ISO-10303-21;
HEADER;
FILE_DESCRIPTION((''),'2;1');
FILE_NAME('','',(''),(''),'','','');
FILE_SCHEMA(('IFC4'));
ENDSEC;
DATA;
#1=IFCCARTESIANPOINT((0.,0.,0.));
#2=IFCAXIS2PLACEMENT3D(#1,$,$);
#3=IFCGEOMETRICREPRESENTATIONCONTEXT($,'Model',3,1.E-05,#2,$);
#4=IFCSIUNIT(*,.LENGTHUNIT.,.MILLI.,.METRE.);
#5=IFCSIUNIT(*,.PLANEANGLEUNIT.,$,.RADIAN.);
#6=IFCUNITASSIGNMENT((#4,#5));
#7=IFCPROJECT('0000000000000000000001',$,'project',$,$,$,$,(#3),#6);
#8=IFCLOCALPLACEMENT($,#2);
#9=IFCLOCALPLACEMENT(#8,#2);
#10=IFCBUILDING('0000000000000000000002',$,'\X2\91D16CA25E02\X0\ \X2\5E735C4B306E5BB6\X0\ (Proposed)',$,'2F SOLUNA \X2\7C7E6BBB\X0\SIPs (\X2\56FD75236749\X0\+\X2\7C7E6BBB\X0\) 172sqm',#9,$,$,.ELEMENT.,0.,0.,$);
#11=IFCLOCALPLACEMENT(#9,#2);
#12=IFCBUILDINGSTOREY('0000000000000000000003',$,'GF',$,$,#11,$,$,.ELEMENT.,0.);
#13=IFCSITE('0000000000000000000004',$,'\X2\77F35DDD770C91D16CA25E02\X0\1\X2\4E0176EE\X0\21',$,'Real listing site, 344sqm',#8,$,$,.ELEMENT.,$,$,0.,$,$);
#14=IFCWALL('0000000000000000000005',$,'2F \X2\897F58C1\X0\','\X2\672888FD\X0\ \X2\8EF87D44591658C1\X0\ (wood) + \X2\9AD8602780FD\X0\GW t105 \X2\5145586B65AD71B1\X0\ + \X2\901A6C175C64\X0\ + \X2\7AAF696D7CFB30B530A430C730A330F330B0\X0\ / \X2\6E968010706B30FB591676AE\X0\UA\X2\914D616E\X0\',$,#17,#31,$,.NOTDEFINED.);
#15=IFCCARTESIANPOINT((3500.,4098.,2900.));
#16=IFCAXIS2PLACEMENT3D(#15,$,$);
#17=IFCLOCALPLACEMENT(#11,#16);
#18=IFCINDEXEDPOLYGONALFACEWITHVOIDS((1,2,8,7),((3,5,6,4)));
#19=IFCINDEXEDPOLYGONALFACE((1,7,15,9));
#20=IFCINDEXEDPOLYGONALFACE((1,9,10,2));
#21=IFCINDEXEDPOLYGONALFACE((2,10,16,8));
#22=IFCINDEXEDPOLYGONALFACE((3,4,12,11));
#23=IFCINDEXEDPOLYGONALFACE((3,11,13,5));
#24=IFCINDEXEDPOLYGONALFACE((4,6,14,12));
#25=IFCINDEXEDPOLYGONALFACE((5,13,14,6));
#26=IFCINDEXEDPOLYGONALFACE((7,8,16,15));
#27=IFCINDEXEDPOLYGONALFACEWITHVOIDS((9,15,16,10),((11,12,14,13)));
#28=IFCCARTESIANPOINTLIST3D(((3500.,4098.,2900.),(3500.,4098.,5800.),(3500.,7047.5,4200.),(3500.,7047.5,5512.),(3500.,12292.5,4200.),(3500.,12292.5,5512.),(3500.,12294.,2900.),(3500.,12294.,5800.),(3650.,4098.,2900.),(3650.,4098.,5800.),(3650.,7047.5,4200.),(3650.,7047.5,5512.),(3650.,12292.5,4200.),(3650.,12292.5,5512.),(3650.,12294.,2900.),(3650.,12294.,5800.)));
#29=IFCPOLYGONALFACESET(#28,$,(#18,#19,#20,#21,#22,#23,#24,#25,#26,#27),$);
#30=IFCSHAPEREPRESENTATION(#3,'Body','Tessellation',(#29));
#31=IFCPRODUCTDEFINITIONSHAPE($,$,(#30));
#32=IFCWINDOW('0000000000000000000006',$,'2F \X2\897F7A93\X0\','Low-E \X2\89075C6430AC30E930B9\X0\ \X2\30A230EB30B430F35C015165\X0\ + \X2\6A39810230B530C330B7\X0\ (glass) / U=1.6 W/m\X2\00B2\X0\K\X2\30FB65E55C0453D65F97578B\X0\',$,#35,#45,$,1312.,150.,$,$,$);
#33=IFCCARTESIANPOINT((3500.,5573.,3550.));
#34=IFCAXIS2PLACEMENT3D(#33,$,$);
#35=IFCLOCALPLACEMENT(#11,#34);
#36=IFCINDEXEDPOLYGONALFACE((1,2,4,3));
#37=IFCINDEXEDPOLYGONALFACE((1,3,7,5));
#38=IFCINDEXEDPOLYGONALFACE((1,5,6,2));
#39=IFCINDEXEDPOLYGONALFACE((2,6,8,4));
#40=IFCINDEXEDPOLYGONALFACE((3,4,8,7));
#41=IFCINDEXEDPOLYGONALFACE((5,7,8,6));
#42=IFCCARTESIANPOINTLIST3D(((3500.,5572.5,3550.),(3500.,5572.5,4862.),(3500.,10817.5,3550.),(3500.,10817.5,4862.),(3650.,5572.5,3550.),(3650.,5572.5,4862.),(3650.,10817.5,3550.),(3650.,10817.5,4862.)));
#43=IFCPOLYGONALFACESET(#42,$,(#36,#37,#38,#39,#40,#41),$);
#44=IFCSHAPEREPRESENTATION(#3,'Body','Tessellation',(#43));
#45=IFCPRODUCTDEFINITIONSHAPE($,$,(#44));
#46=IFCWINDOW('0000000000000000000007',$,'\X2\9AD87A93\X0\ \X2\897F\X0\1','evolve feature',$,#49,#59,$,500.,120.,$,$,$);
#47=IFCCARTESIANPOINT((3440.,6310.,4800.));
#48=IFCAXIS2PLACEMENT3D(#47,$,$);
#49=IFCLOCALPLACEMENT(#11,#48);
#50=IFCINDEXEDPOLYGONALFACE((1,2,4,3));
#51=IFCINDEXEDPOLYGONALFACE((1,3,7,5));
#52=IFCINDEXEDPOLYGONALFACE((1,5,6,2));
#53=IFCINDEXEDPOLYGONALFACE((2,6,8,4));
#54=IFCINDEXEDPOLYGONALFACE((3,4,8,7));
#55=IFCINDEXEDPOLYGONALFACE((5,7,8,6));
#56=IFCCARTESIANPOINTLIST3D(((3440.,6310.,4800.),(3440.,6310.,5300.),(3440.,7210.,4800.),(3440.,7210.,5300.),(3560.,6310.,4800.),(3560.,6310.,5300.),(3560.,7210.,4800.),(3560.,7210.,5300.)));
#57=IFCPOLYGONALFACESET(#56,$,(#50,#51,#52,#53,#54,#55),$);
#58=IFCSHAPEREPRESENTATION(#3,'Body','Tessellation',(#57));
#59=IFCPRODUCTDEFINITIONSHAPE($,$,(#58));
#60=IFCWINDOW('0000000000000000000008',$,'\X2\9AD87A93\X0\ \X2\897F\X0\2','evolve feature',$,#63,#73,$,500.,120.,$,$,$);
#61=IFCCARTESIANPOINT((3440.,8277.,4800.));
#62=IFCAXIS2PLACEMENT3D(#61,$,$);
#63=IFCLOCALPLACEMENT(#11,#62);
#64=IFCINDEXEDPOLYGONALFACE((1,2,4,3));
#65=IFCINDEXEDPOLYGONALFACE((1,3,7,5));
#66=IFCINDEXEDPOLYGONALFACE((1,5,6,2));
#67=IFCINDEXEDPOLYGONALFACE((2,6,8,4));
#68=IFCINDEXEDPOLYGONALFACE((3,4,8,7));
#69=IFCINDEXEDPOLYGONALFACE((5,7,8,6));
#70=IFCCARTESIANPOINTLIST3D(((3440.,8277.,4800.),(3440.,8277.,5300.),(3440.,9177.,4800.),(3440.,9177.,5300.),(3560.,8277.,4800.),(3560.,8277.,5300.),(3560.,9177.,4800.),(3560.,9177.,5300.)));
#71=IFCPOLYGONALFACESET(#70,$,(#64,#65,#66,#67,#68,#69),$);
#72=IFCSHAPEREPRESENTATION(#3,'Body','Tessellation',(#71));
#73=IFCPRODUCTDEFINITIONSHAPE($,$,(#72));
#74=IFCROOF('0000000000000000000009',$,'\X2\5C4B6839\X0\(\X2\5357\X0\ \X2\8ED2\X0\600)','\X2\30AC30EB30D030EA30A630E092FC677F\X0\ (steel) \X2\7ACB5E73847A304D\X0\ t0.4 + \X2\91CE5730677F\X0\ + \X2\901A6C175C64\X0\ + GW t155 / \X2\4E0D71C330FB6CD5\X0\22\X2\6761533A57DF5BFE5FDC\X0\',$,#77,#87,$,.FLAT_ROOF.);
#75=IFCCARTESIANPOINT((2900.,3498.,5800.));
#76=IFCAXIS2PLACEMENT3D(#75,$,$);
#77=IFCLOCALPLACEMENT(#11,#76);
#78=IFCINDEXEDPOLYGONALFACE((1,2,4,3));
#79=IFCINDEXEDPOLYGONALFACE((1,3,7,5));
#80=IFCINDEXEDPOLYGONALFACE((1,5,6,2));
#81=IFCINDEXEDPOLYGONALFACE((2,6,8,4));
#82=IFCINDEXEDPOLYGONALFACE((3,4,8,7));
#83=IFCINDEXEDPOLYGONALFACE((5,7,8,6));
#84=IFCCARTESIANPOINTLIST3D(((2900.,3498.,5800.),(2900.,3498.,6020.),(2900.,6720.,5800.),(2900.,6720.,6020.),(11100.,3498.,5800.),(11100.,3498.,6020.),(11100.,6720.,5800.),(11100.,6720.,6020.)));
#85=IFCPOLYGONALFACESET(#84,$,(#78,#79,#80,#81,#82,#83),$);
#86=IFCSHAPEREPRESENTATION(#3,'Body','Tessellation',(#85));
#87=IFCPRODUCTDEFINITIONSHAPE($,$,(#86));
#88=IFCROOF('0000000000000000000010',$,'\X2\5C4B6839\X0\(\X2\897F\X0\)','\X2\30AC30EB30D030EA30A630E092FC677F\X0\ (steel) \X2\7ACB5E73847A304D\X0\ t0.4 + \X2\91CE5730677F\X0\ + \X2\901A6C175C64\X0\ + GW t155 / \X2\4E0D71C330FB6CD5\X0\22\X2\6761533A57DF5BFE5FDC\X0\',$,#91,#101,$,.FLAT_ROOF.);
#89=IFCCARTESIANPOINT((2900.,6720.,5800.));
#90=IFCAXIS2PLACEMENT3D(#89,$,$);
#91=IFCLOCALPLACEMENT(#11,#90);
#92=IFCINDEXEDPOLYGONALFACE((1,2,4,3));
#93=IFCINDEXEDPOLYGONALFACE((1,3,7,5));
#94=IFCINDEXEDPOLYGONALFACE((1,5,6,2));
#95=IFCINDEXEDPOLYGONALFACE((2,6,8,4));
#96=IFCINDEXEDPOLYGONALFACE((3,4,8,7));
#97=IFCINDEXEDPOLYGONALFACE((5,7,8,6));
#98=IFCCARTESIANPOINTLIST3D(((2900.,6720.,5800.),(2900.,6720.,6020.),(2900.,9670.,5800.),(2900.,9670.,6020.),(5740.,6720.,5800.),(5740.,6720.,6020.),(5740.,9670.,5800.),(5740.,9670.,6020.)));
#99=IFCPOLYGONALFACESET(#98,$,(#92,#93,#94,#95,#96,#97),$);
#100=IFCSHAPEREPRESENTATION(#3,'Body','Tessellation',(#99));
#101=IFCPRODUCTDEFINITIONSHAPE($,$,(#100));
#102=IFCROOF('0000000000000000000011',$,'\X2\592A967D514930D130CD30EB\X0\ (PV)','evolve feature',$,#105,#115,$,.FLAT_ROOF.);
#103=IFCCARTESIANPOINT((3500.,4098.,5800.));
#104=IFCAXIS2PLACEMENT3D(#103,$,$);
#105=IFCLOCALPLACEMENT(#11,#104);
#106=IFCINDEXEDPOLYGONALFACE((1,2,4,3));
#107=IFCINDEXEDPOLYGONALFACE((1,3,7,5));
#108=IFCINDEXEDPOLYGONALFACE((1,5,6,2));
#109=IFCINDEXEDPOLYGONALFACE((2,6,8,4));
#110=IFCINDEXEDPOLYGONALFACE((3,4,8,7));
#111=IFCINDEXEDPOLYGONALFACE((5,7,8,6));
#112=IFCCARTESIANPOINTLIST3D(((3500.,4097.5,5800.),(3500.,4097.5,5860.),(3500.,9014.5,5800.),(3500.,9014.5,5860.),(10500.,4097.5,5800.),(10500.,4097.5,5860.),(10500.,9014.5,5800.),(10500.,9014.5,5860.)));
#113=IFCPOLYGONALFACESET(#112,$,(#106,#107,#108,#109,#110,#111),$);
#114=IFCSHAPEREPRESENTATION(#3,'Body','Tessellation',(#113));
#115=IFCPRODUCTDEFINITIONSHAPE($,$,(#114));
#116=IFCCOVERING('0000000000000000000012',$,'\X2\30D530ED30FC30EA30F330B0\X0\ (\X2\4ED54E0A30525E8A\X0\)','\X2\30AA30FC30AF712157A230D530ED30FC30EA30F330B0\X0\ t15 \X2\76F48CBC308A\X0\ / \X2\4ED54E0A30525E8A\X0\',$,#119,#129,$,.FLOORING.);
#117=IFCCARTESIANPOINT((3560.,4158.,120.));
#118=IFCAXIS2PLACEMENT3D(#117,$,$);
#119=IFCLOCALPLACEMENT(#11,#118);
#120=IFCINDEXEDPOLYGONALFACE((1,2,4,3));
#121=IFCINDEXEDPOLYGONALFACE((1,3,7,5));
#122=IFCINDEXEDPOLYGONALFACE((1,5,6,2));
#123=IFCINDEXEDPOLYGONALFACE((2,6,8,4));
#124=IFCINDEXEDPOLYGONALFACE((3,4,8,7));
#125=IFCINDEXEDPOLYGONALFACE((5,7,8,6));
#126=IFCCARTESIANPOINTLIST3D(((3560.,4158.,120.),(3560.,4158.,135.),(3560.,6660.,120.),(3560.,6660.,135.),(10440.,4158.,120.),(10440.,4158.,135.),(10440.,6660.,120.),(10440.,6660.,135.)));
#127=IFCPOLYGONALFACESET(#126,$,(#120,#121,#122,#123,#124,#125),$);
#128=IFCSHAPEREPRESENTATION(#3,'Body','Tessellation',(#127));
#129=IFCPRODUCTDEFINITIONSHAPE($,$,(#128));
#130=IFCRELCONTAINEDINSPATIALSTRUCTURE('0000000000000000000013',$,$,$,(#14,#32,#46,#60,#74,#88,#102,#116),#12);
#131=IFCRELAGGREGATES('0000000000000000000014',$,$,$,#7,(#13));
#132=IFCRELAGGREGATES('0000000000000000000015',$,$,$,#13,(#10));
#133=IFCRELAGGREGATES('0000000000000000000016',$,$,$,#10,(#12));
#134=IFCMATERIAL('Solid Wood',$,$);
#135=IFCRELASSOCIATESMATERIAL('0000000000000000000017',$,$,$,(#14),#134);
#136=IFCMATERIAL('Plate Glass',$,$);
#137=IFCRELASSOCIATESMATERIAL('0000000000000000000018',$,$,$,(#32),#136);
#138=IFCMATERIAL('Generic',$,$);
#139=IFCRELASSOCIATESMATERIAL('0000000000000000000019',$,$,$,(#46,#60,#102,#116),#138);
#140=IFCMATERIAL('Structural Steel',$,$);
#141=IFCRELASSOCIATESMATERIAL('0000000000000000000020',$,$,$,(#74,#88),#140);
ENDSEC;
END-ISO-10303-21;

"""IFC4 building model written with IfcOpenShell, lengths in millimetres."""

from ifc_helpers import new_model, si_unit, frame, frame_2d, origin, place, context, project, spatial, rectangle, extrude, material, element, fill, save


model = new_model("IFC4")

# Units and contexts
model_context = context("Model", 3, precision=1e-05, world=origin())
ifc_project = project(units=[si_unit("LENGTHUNIT", "METRE", prefix="MILLI"), si_unit("PLANEANGLEUNIT", "RADIAN")], contexts=[model_context])

# Site, building, storey
site_placement = place(None, origin())
site = spatial("IfcSite", under=ifc_project, at=site_placement, Name="石川県金沢市1丁目21", ObjectType="Real listing site, 344sqm", CompositionType="ELEMENT", RefElevation=0.0)
building_placement = place(site_placement, origin())
building = spatial("IfcBuilding", under=site, at=building_placement, Name="金沢市 平屋の家 (Proposed)", ObjectType="2F SOLUNA 籾殻SIPs (国産杉+籾殻) 172sqm", CompositionType="ELEMENT", ElevationOfRefHeight=0.0, ElevationOfTerrain=0.0)
storey_placement = place(building_placement, origin())
storey = spatial("IfcBuildingStorey", under=building, at=storey_placement, Name="GF", CompositionType="ELEMENT", Elevation=0.0)

# Shared definitions
ifc_material_1 = material(Name="Solid Wood")
ifc_material_2 = material(Name="Generic")

# Shared definitions
ifc_material_3 = material(Name="Plate Glass")

# Wall, openings, windows
wall_1_placement = place(storey_placement, frame((3500.0, 4098.0, 2900.0)))
wall_1 = element("IfcWall", 1, at=wall_1_placement, inside=storey, material=ifc_material_1, Name="2F 西壁", Description="木製 軸組外壁 (wood) + 高性能GW t105 充填断熱 + 通気層 + 窯業系サイディング / 準耐火・外皮UA配慮", PredefinedType="NOTDEFINED", context=model_context, shape_type="SweptSolid", body=[
    extrude(rectangle(XDim=150.0, YDim=8196.0, at=frame_2d((75.0, 4098.0))), frame((3500.0, 4098.0, 2900.0)), (0.0, 0.0, 1.0), 2900.0),
])
opening_1_placement = place(storey_placement, frame((3500.0, 5573.0, 3550.0)))
opening_1 = element("IfcOpeningElement", 2, at=opening_1_placement, cuts=wall_1, PredefinedType="NOTDEFINED", context=model_context, shape_type="SweptSolid", body=[
    extrude(rectangle(XDim=150.0, YDim=5245.0, at=frame_2d((75.0, 2622.0))), frame((3500.0, 5573.0, 3550.0)), (0.0, 0.0, 1.0), 1312.0),
])
opening_2_placement = place(storey_placement, frame((3440.0, 6310.0, 4800.0)))
opening_2 = element("IfcOpeningElement", 3, at=opening_2_placement, cuts=wall_1, PredefinedType="NOTDEFINED", context=model_context, shape_type="SweptSolid", body=[
    extrude(rectangle(XDim=120.0, YDim=900.0, at=frame_2d((60.0, 450.0))), frame((3440.0, 6310.0, 4800.0)), (0.0, 0.0, 1.0), 500.0),
])
opening_3_placement = place(storey_placement, frame((3440.0, 8277.0, 4800.0)))
opening_3 = element("IfcOpeningElement", 4, at=opening_3_placement, cuts=wall_1, PredefinedType="NOTDEFINED", context=model_context, shape_type="SweptSolid", body=[
    extrude(rectangle(XDim=120.0, YDim=900.0, at=frame_2d((60.0, 450.0))), frame((3440.0, 8277.0, 4800.0)), (0.0, 0.0, 1.0), 500.0),
])
window_1_placement = place(storey_placement, frame((3500.0, 5573.0, 3550.0)))
window_1 = element("IfcWindow", 5, at=window_1_placement, inside=storey, material=ifc_material_3, Name="2F 西窓", Description="Low-E 複層ガラス アルゴン封入 + 樹脂サッシ (glass) / U=1.6 W/m²K・日射取得型", OverallHeight=1312.0, OverallWidth=150.0, context=model_context, shape_type="SweptSolid", body=[
    extrude(rectangle(XDim=150.0, YDim=5245.0, at=frame_2d((75.0, 2622.0))), frame((3500.0, 5573.0, 3550.0)), (0.0, 0.0, 1.0), 1312.0),
])
fill(opening_1, window_1)
window_2_placement = place(storey_placement, frame((3440.0, 6310.0, 4800.0)))
window_2 = element("IfcWindow", 6, at=window_2_placement, inside=storey, material=ifc_material_2, Name="高窓 西1", Description="evolve feature", OverallHeight=500.0, OverallWidth=120.0, context=model_context, shape_type="SweptSolid", body=[
    extrude(rectangle(XDim=120.0, YDim=900.0, at=frame_2d((60.0, 450.0))), frame((3440.0, 6310.0, 4800.0)), (0.0, 0.0, 1.0), 500.0),
])
fill(opening_2, window_2)
window_3_placement = place(storey_placement, frame((3440.0, 8277.0, 4800.0)))
window_3 = element("IfcWindow", 7, at=window_3_placement, inside=storey, material=ifc_material_2, Name="高窓 西2", Description="evolve feature", OverallHeight=500.0, OverallWidth=120.0, context=model_context, shape_type="SweptSolid", body=[
    extrude(rectangle(XDim=120.0, YDim=900.0, at=frame_2d((60.0, 450.0))), frame((3440.0, 8277.0, 4800.0)), (0.0, 0.0, 1.0), 500.0),
])
fill(opening_3, window_3)

# Roofs
ifc_material_4 = material(Name="Structural Steel")
roof_1_placement = place(storey_placement, frame((2900.0, 3498.0, 5800.0)))
element("IfcRoof", 8, at=roof_1_placement, inside=storey, material=ifc_material_4, Name="屋根(南 軒600)", Description="ガルバリウム鋼板 (steel) 立平葺き t0.4 + 野地板 + 通気層 + GW t155 / 不燃・法22条区域対応", PredefinedType="FLAT_ROOF", context=model_context, shape_type="SweptSolid", body=[
    extrude(rectangle(XDim=8200.0, YDim=3222.0, at=frame_2d((4100.0, 1611.0))), frame((2900.0, 3498.0, 5800.0)), (0.0, 0.0, 1.0), 220.0),
])
roof_2_placement = place(storey_placement, frame((2900.0, 6720.0, 5800.0)))
element("IfcRoof", 9, at=roof_2_placement, inside=storey, material=ifc_material_4, Name="屋根(西)", Description="ガルバリウム鋼板 (steel) 立平葺き t0.4 + 野地板 + 通気層 + GW t155 / 不燃・法22条区域対応", PredefinedType="FLAT_ROOF", context=model_context, shape_type="SweptSolid", body=[
    extrude(rectangle(XDim=2840.0, YDim=2950.0, at=frame_2d((1420.0, 1475.0))), frame((2900.0, 6720.0, 5800.0)), (0.0, 0.0, 1.0), 220.0),
])
roof_3_placement = place(storey_placement, frame((3500.0, 4098.0, 5800.0)))
element("IfcRoof", 10, at=roof_3_placement, inside=storey, material=ifc_material_2, Name="太陽光パネル (PV)", Description="evolve feature", PredefinedType="FLAT_ROOF", context=model_context, shape_type="SweptSolid", body=[
    extrude(rectangle(XDim=7000.0, YDim=4917.0, at=frame_2d((3500.0, 2458.0))), frame((3500.0, 4098.0, 5800.0)), (0.0, 0.0, 1.0), 60.0),
])

# Covering
covering_placement = place(storey_placement, frame((3560.0, 4158.0, 120.0)))
element("IfcCovering", 11, at=covering_placement, inside=storey, material=ifc_material_2, Name="フローリング (仕上げ床)", Description="オーク無垢フローリング t15 直貼り / 仕上げ床", PredefinedType="FLOORING", context=model_context, shape_type="SweptSolid", body=[
    extrude(rectangle(XDim=6880.0, YDim=2502.0, at=frame_2d((3440.0, 1251.0))), frame((3560.0, 4158.0, 120.0)), (0.0, 0.0, 1.0), 15.0),
])

save(model, "model.ifc")
